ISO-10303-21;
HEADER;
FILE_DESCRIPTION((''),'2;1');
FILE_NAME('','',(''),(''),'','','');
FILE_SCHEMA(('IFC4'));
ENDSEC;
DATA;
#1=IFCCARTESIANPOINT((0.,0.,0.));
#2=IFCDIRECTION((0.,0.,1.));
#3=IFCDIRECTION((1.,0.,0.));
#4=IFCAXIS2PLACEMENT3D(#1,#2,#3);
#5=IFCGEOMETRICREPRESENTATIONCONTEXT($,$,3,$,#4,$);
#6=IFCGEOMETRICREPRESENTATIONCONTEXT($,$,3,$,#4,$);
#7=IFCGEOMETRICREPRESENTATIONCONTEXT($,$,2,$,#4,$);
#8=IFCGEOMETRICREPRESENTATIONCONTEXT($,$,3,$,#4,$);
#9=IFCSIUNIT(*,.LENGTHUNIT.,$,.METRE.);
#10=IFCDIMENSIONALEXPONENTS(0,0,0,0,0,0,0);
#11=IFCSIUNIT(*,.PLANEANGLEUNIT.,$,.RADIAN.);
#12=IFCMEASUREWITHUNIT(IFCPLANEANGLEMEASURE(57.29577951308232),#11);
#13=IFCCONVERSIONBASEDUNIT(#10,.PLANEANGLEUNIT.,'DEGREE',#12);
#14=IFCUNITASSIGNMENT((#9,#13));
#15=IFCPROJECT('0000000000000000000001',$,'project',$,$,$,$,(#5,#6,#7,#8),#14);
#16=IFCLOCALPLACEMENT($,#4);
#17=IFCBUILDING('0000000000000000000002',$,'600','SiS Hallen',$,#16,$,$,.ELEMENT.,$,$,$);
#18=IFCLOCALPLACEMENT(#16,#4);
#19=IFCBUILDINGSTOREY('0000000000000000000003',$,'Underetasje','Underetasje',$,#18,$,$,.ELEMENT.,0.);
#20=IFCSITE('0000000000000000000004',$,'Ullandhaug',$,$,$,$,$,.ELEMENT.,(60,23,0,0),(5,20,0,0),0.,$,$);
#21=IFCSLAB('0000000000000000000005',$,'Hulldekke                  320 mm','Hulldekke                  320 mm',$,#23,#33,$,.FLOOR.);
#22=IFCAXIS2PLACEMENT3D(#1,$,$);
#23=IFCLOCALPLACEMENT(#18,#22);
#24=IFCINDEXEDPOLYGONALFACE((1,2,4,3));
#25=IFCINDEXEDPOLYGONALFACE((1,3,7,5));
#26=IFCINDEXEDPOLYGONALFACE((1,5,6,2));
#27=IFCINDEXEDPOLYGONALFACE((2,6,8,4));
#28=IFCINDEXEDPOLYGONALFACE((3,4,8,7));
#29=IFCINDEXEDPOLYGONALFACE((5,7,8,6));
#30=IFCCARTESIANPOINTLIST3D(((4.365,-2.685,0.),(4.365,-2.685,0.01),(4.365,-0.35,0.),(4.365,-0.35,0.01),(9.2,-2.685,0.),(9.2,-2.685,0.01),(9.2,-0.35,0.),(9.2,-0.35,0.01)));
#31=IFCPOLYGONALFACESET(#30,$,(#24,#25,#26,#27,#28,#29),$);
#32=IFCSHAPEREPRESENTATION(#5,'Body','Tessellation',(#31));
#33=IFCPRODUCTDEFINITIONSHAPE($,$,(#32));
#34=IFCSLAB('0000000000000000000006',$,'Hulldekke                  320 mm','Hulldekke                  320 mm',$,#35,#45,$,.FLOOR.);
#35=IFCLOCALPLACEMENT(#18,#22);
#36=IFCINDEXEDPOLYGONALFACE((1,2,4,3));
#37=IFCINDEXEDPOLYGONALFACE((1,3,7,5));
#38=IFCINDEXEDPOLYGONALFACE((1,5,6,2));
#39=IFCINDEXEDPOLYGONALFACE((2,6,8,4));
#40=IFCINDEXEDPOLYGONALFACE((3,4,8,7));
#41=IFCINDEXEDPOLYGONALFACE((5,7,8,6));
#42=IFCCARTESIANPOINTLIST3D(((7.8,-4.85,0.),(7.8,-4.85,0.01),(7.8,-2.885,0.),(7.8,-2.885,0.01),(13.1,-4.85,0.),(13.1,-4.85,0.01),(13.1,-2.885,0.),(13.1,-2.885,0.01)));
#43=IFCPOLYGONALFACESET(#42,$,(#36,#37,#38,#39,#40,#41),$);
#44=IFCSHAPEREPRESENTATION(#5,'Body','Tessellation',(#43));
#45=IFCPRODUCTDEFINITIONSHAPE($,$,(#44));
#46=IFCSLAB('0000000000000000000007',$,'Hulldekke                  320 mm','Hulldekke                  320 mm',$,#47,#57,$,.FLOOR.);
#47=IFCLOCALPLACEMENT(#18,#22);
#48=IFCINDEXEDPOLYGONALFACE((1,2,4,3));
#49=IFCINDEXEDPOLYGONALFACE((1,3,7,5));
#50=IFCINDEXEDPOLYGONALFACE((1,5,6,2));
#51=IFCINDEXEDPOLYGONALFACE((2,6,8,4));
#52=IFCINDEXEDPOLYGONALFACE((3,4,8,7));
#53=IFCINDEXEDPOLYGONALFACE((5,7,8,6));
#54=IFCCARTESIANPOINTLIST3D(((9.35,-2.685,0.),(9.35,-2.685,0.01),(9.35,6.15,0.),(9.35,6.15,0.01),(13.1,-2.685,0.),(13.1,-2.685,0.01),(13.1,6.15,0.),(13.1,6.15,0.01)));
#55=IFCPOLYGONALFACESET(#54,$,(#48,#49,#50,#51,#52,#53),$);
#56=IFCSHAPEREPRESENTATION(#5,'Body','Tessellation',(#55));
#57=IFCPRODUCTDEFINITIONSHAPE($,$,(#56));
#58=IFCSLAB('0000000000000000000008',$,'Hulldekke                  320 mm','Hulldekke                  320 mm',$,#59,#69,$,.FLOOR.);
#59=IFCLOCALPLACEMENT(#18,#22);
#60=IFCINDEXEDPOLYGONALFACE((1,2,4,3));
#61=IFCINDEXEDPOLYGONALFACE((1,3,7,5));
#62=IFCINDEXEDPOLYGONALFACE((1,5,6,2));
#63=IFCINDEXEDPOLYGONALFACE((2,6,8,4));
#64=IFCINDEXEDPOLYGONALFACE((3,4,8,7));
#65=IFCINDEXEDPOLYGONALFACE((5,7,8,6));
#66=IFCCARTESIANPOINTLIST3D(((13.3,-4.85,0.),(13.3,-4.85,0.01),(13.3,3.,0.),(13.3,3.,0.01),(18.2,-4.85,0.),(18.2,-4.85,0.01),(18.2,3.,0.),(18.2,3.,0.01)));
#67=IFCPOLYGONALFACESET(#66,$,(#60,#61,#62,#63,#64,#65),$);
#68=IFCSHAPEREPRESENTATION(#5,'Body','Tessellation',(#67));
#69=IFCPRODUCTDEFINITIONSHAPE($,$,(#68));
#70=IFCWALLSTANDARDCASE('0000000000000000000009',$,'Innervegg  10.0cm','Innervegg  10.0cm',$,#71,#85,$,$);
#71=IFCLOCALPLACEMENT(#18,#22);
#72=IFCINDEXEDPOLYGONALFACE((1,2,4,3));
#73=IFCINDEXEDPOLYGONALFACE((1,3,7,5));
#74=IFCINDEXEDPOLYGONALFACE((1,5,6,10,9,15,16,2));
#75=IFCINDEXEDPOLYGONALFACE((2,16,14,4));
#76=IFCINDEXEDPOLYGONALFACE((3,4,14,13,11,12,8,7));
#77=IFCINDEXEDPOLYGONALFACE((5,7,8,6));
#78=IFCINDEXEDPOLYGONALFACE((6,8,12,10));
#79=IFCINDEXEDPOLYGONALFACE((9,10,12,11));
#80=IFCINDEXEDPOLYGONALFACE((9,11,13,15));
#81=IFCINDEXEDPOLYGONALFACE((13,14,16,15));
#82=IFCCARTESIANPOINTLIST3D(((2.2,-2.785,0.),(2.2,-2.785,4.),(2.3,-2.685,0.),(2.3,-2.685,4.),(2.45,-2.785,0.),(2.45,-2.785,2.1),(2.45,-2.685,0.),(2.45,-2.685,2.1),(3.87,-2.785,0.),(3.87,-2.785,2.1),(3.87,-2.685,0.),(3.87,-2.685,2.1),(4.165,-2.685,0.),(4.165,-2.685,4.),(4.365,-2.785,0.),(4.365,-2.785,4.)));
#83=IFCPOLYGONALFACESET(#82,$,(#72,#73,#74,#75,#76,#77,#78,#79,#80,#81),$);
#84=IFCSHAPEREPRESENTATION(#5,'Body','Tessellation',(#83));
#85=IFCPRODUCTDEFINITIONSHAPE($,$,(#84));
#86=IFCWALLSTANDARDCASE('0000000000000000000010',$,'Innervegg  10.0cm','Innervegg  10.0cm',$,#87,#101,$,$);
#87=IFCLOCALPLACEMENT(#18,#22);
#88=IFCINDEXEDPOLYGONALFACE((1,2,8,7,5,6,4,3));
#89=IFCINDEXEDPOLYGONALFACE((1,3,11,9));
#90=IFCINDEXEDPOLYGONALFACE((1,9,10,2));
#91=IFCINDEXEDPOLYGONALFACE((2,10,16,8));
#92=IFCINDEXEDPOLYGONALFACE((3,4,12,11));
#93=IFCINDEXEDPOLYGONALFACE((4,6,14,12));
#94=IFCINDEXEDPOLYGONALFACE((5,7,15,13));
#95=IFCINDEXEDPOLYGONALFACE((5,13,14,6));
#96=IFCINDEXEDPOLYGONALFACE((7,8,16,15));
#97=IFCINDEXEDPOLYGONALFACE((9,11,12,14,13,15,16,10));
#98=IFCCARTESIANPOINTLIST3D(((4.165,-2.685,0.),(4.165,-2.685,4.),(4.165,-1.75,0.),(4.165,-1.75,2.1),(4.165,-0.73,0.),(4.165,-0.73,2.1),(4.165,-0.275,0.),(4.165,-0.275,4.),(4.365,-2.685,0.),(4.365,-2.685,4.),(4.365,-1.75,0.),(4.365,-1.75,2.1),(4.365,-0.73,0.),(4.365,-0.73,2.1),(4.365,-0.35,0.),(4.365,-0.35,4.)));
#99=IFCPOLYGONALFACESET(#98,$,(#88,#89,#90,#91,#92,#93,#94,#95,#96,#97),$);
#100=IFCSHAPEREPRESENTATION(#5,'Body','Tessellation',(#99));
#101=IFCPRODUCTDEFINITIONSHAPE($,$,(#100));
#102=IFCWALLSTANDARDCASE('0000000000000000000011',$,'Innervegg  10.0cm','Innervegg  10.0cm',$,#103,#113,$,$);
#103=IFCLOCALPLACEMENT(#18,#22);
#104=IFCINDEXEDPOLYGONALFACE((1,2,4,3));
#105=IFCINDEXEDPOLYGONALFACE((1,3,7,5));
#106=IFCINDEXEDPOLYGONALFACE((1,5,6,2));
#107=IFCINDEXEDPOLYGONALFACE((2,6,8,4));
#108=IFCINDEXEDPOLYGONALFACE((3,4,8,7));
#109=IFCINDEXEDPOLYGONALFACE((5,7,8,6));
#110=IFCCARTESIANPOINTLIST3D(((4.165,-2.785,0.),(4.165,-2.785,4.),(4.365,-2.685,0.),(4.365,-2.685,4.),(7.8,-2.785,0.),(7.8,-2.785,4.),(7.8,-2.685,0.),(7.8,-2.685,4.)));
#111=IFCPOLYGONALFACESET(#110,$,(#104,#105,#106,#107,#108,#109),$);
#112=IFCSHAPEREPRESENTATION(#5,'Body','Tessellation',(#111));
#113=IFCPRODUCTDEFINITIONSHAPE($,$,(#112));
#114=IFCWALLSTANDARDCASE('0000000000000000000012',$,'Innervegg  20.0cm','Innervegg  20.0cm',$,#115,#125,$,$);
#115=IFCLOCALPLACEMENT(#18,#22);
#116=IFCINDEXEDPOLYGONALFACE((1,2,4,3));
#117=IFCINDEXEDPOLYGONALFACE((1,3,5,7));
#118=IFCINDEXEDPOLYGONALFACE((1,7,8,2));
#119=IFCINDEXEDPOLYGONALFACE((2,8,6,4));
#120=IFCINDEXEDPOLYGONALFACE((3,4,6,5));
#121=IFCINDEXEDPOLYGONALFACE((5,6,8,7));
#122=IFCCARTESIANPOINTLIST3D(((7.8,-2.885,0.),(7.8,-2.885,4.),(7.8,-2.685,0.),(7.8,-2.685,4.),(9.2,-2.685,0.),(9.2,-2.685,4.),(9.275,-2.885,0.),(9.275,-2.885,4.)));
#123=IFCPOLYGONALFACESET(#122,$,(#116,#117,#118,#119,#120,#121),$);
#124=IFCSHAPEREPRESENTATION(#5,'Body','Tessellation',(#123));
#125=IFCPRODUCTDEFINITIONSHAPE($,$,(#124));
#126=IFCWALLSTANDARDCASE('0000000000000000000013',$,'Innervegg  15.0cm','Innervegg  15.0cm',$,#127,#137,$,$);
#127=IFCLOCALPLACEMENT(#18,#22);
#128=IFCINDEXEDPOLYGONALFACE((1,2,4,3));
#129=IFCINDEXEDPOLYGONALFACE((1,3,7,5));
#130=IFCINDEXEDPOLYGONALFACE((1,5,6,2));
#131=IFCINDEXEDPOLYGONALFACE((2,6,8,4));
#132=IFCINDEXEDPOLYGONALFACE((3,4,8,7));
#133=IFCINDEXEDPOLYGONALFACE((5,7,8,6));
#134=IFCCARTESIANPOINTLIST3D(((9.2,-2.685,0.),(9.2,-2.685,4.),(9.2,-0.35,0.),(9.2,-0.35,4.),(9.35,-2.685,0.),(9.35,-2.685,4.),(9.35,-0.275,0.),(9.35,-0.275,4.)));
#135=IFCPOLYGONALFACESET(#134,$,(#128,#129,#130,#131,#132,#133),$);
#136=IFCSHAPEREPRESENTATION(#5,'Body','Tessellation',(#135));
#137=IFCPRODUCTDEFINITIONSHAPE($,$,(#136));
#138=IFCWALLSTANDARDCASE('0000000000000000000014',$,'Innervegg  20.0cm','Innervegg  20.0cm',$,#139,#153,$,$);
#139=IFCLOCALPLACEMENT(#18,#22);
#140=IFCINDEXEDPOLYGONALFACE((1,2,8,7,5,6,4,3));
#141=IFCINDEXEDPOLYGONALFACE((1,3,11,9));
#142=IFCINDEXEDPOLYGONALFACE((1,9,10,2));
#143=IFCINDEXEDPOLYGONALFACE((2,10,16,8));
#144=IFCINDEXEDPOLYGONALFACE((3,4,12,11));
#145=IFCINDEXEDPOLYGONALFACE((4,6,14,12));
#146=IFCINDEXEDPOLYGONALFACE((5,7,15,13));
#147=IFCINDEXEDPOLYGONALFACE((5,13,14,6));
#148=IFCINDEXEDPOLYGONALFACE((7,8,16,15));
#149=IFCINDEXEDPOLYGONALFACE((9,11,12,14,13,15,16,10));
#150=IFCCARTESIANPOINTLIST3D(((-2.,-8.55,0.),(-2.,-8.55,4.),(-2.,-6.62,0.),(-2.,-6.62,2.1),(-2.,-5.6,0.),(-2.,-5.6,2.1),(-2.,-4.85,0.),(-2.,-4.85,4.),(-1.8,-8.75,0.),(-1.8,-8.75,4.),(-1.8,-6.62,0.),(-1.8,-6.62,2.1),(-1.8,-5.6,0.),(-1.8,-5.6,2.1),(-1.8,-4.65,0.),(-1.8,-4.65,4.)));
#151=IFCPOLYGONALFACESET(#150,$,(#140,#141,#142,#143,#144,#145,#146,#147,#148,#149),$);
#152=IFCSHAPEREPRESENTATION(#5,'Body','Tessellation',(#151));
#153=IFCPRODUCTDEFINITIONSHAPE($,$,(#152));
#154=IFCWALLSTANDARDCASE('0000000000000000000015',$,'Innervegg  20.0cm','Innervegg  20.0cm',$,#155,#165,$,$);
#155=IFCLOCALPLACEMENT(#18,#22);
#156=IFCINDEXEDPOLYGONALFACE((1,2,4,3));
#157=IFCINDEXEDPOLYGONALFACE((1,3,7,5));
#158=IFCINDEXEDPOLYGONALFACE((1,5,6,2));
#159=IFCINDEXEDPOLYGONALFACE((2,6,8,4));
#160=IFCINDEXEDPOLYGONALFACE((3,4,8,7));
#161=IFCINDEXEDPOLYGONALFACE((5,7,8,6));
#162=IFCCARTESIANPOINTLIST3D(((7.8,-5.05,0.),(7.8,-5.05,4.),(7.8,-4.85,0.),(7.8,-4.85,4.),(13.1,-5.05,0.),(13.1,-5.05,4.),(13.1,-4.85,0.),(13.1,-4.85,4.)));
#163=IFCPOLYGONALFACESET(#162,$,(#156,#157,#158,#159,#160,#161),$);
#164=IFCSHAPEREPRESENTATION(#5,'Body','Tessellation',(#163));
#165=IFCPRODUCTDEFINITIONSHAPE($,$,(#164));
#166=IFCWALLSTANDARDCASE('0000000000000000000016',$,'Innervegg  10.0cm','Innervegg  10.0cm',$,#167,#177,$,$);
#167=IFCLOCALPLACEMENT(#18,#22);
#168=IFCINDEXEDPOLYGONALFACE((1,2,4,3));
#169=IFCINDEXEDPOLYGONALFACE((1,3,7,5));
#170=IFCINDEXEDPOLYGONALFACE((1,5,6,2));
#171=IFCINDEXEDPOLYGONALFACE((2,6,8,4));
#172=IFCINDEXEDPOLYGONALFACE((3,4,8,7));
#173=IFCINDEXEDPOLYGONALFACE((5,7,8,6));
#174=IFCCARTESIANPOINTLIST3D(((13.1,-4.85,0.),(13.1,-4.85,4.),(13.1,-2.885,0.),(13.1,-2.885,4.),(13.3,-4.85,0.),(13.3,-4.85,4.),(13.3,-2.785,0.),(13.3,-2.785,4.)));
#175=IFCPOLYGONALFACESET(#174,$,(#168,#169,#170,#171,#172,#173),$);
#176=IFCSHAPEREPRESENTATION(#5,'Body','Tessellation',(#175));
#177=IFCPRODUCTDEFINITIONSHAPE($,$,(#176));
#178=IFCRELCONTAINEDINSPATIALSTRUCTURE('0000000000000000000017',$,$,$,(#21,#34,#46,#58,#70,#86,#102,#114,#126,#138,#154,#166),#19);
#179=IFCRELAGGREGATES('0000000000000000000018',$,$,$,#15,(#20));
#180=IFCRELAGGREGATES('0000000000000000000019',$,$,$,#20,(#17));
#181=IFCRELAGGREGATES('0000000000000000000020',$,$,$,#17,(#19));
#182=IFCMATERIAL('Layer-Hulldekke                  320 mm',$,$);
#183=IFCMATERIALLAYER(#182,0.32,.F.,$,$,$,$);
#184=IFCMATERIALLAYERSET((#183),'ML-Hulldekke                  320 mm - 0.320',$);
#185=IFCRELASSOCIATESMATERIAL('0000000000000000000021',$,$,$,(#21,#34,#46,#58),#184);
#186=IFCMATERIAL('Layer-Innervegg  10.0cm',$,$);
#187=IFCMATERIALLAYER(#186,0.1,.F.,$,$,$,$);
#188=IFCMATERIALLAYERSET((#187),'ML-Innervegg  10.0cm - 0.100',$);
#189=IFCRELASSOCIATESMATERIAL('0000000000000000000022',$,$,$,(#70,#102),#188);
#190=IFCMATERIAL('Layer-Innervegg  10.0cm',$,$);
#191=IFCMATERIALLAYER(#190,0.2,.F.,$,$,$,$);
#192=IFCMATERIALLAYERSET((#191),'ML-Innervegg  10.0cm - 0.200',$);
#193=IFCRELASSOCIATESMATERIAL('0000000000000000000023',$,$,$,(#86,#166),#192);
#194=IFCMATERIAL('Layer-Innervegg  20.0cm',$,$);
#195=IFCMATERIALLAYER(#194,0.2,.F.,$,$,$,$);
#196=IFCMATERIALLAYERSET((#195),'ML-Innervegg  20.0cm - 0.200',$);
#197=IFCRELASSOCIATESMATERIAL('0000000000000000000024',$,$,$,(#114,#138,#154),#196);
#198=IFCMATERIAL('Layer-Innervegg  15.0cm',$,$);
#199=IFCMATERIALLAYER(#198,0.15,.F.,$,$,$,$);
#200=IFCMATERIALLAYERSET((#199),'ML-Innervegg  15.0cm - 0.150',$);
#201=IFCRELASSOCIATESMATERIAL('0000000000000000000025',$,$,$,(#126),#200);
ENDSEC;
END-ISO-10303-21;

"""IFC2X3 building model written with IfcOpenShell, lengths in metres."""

from ifc_helpers import new_model, entity, si_unit, converted_unit, frame, origin_with_axes, place, context, project, spatial, polyline, outline, extrude, material, layer, layer_set, layer_usage, element, save


model = new_model("IFC2X3")

# Units and contexts
context_of_model_1 = context(None, 3, world=origin_with_axes())
context_of_model_2 = context(None, 3, world=origin_with_axes())
context_of_model_3 = context(None, 2, world=origin_with_axes())
context_of_model_4 = context(None, 3, world=origin_with_axes())
ifc_project = project(units=[si_unit("LENGTHUNIT", "METRE"), converted_unit("PLANEANGLEUNIT", "DEGREE", entity("IfcPlaneAngleMeasure", 57.29577951308232), si_unit("PLANEANGLEUNIT", "RADIAN"), dimensions=[0, 0, 0, 0, 0, 0, 0])], contexts=[context_of_model_1, context_of_model_2, context_of_model_3, context_of_model_4])

# Site, building, storey
site = spatial("IfcSite", under=ifc_project, Name="Ullandhaug", CompositionType="ELEMENT", RefLatitude=(60, 23, 0, 0), RefLongitude=(5, 20, 0, 0), RefElevation=0.0)
building_placement = place(None, origin_with_axes())
building = spatial("IfcBuilding", under=site, at=building_placement, Name="600", Description="SiS Hallen", CompositionType="ELEMENT")
storey_placement = place(building_placement, origin_with_axes())
storey = spatial("IfcBuildingStorey", under=building, at=storey_placement, Name="Underetasje", Description="Underetasje", CompositionType="ELEMENT", Elevation=0.0)

# Slabs
ifc_material_1 = material(Name="Layer-Hulldekke                  320 mm")
ifc_layer_1 = layer(ifc_material_1, 0.32, ventilated=False)
ifc_layer_set_1 = layer_set([ifc_layer_1], Name="ML-Hulldekke                  320 mm - 0.320")
ifc_layer_usage_1 = layer_usage(ifc_layer_set_1, "AXIS2", "POSITIVE", 0.0)
slab_1_placement = place(storey_placement, frame((4.365, -2.685, 0.0), z_axis=(0.0, 0.0, 1.0), x_axis=(1.0, 0.0, 0.0)))
element("IfcSlab", 1, at=slab_1_placement, inside=storey, material=ifc_layer_usage_1, Name="Hulldekke                  320 mm", Description="Hulldekke                  320 mm", PredefinedType="FLOOR", context=context_of_model_1, shape_type="SweptSolid", body=[
    extrude(outline(polyline([(0.0, 0.0), (4.835, 0.0), (4.835, 2.335), (0.0, 2.335), (0.0, 0.0)])), origin_with_axes(), (0.0, 0.0, 1.0), 0.01),
])
slab_2_placement = place(storey_placement, frame((7.8, -4.85, 0.0), z_axis=(0.0, 0.0, 1.0), x_axis=(1.0, 0.0, 0.0)))
element("IfcSlab", 2, at=slab_2_placement, inside=storey, material=ifc_layer_usage_1, Name="Hulldekke                  320 mm", Description="Hulldekke                  320 mm", PredefinedType="FLOOR", context=context_of_model_1, shape_type="SweptSolid", body=[
    extrude(outline(polyline([(0.0, 0.0), (5.3, 0.0), (5.3, 1.965), (0.0, 1.965), (0.0, 0.0)])), origin_with_axes(), (0.0, 0.0, 1.0), 0.01),
])
slab_3_placement = place(storey_placement, frame((9.35, -2.685, 0.0), z_axis=(0.0, 0.0, 1.0), x_axis=(1.0, 0.0, 0.0)))
element("IfcSlab", 3, at=slab_3_placement, inside=storey, material=ifc_layer_usage_1, Name="Hulldekke                  320 mm", Description="Hulldekke                  320 mm", PredefinedType="FLOOR", context=context_of_model_1, shape_type="SweptSolid", body=[
    extrude(outline(polyline([(0.0, 0.0), (3.75, 0.0), (3.75, 8.835), (0.0, 8.835), (0.0, 0.0)])), origin_with_axes(), (0.0, 0.0, 1.0), 0.01),
])
slab_4_placement = place(storey_placement, frame((13.3, -4.85, 0.0), z_axis=(0.0, 0.0, 1.0), x_axis=(1.0, 0.0, 0.0)))
element("IfcSlab", 4, at=slab_4_placement, inside=storey, material=ifc_layer_usage_1, Name="Hulldekke                  320 mm", Description="Hulldekke                  320 mm", PredefinedType="FLOOR", context=context_of_model_1, shape_type="SweptSolid", body=[
    extrude(outline(polyline([(0.0, 0.0), (4.9, 0.0), (4.9, 7.85), (0.0, 7.85), (0.0, 0.0)])), origin_with_axes(), (0.0, 0.0, 1.0), 0.01),
])

# Walls, openings
ifc_material_2 = material(Name="Layer-Innervegg  10.0cm")
ifc_layer_2 = layer(ifc_material_2, 0.1, ventilated=False)
ifc_layer_set_2 = layer_set([ifc_layer_2], Name="ML-Innervegg  10.0cm - 0.100")
ifc_layer_usage_2 = layer_usage(ifc_layer_set_2, "AXIS2", "POSITIVE", 0.0)
wall_1_placement = place(storey_placement, frame((2.2, -2.785, 0.0), z_axis=(0.0, 0.0, 1.0), x_axis=(1.0, 0.0, 0.0)))
wall_1 = element("IfcWallStandardCase", 5, at=wall_1_placement, inside=storey, material=ifc_layer_usage_2, Name="Innervegg  10.0cm", Description="Innervegg  10.0cm", context=context_of_model_1, shape_type="SweptSolid", body=[
    extrude(outline(polyline([(0.0, 0.0), (2.165, 0.0), (1.965, 0.1), (0.1, 0.1), (0.0, 0.0)])), origin_with_axes(), (0.0, 0.0, 1.0), 4.0),
])
opening_1_placement = place(wall_1_placement, frame((0.25, 0.1, 0.0), z_axis=(0.0, 0.0, 1.0), x_axis=(1.0, 0.0, 0.0)))
element("IfcOpeningElement", 6, at=opening_1_placement, cuts=wall_1, context=context_of_model_1, shape_type="SweptSolid", body=[
    extrude(outline(polyline([(0.0, 0.0), (2.1, 0.0), (2.1, 1.42), (0.0, 1.42), (0.0, 0.0)])), frame((0.0, 0.0, 0.0), z_axis=(0.0, 1.0, 0.0), x_axis=(0.0, 0.0, 1.0)), (0.0, 0.0, -1.0), 0.1),
])
ifc_material_3 = material(Name="Layer-Innervegg  10.0cm")
ifc_layer_3 = layer(ifc_material_3, 0.2, ventilated=False)
ifc_layer_set_3 = layer_set([ifc_layer_3], Name="ML-Innervegg  10.0cm - 0.200")
ifc_layer_usage_3 = layer_usage(ifc_layer_set_3, "AXIS2", "POSITIVE", 0.0)
wall_2_placement = place(storey_placement, frame((4.365, -2.685, 0.0), z_axis=(0.0, 0.0, 1.0), x_axis=(0.0, 1.0, 0.0)))
wall_2 = element("IfcWallStandardCase", 7, at=wall_2_placement, inside=storey, material=ifc_layer_usage_3, Name="Innervegg  10.0cm", Description="Innervegg  10.0cm", context=context_of_model_1, shape_type="SweptSolid", body=[
    extrude(outline(polyline([(0.0, 0.0), (2.335, 0.0), (2.41, 0.2), (0.0, 0.2), (0.0, 0.0)])), frame((0.0, 0.0, 0.0), z_axis=(0.0, 0.0, 1.0), x_axis=(1.0, 0.0, 0.0)), (0.0, 0.0, 1.0), 4.0),
])
opening_2_placement = place(wall_2_placement, frame((0.935, 0.2, 0.0), z_axis=(0.0, 0.0, 1.0), x_axis=(1.0, 0.0, 0.0)))
element("IfcOpeningElement", 8, at=opening_2_placement, cuts=wall_2, context=context_of_model_1, shape_type="SweptSolid", body=[
    extrude(outline(polyline([(0.0, 0.0), (2.1, 0.0), (2.1, 1.02), (0.0, 1.02), (0.0, 0.0)])), frame((0.0, 0.0, 0.0), z_axis=(0.0, 1.0, 0.0), x_axis=(0.0, 0.0, 1.0)), (0.0, 0.0, -1.0), 0.2),
])

# Walls
wall_3_placement = place(storey_placement, frame((4.165, -2.785, 0.0), z_axis=(0.0, 0.0, 1.0), x_axis=(1.0, 0.0, 0.0)))
element("IfcWallStandardCase", 9, at=wall_3_placement, inside=storey, material=ifc_layer_usage_2, Name="Innervegg  10.0cm", Description="Innervegg  10.0cm", context=context_of_model_1, shape_type="SweptSolid", body=[
    extrude(outline(polyline([(0.0, 0.0), (3.635, 0.0), (3.635, 0.1), (0.2, 0.1), (0.0, 0.0)])), origin_with_axes(), (0.0, 0.0, 1.0), 4.0),
])
ifc_material_4 = material(Name="Layer-Innervegg  20.0cm")
ifc_layer_4 = layer(ifc_material_4, 0.2, ventilated=False)
ifc_layer_set_4 = layer_set([ifc_layer_4], Name="ML-Innervegg  20.0cm - 0.200")
ifc_layer_usage_4 = layer_usage(ifc_layer_set_4, "AXIS2", "POSITIVE", 0.0)
wall_4_placement = place(storey_placement, frame((7.8, -2.885, 0.0), z_axis=(0.0, 0.0, 1.0), x_axis=(1.0, 0.0, 0.0)))
element("IfcWallStandardCase", 10, at=wall_4_placement, inside=storey, material=ifc_layer_usage_4, Name="Innervegg  20.0cm", Description="Innervegg  20.0cm", context=context_of_model_1, shape_type="SweptSolid", body=[
    extrude(outline(polyline([(0.0, 0.0), (1.475, 0.0), (1.4, 0.2), (0.0, 0.2), (0.0, 0.0)])), origin_with_axes(), (0.0, 0.0, 1.0), 4.0),
])
ifc_material_5 = material(Name="Layer-Innervegg  15.0cm")
ifc_layer_5 = layer(ifc_material_5, 0.15, ventilated=False)
ifc_layer_set_5 = layer_set([ifc_layer_5], Name="ML-Innervegg  15.0cm - 0.150")
ifc_layer_usage_5 = layer_usage(ifc_layer_set_5, "AXIS2", "POSITIVE", 0.0)
wall_5_placement = place(storey_placement, frame((9.35, -2.685, 0.0), z_axis=(0.0, 0.0, 1.0), x_axis=(0.0, 1.0, 0.0)))
element("IfcWallStandardCase", 11, at=wall_5_placement, inside=storey, material=ifc_layer_usage_5, Name="Innervegg  15.0cm", Description="Innervegg  15.0cm", context=context_of_model_1, shape_type="SweptSolid", body=[
    extrude(outline(polyline([(0.0, 0.0), (2.41, 0.0), (2.335, 0.15), (0.0, 0.15), (0.0, 0.0)])), frame((0.0, 0.0, 0.0), z_axis=(0.0, 0.0, 1.0), x_axis=(1.0, 0.0, 0.0)), (0.0, 0.0, 1.0), 4.0),
])

# Wall, opening
wall_6_placement = place(storey_placement, frame((-1.8, -8.75, 0.0), z_axis=(0.0, 0.0, 1.0), x_axis=(0.0, 1.0, 0.0)))
wall_6 = element("IfcWallStandardCase", 12, at=wall_6_placement, inside=storey, material=ifc_layer_usage_4, Name="Innervegg  20.0cm", Description="Innervegg  20.0cm", context=context_of_model_1, shape_type="SweptSolid", body=[
    extrude(outline(polyline([(0.0, 0.0), (4.1, 0.0), (3.9, 0.2), (0.2, 0.2), (0.0, 0.0)])), frame((0.0, 0.0, 0.0), z_axis=(0.0, 0.0, 1.0), x_axis=(1.0, 0.0, 0.0)), (0.0, 0.0, 1.0), 4.0),
])
opening_3_placement = place(wall_6_placement, frame((2.13, 0.2, 0.0), z_axis=(0.0, 0.0, 1.0), x_axis=(1.0, 0.0, 0.0)))
element("IfcOpeningElement", 13, at=opening_3_placement, cuts=wall_6, context=context_of_model_1, shape_type="SweptSolid", body=[
    extrude(outline(polyline([(0.0, 0.0), (2.1, 0.0), (2.1, 1.02), (0.0, 1.02), (0.0, 0.0)])), frame((0.0, 0.0, 0.0), z_axis=(0.0, 1.0, 0.0), x_axis=(0.0, 0.0, 1.0)), (0.0, 0.0, -1.0), 0.2),
])

# Walls
wall_7_placement = place(storey_placement, frame((7.8, -5.05, 0.0), z_axis=(0.0, 0.0, 1.0), x_axis=(1.0, 0.0, 0.0)))
element("IfcWallStandardCase", 14, at=wall_7_placement, inside=storey, material=ifc_layer_usage_4, Name="Innervegg  20.0cm", Description="Innervegg  20.0cm", context=context_of_model_1, shape_type="SweptSolid", body=[
    extrude(outline(polyline([(0.0, 0.0), (5.3, 0.0), (5.3, 0.2), (0.0, 0.2), (0.0, 0.0)])), origin_with_axes(), (0.0, 0.0, 1.0), 4.0),
])
wall_8_placement = place(storey_placement, frame((13.3, -4.85, 0.0), z_axis=(0.0, 0.0, 1.0), x_axis=(0.0, 1.0, 0.0)))
element("IfcWallStandardCase", 15, at=wall_8_placement, inside=storey, material=ifc_layer_usage_3, Name="Innervegg  10.0cm", Description="Innervegg  10.0cm", context=context_of_model_1, shape_type="SweptSolid", body=[
    extrude(outline(polyline([(0.0, 0.0), (2.065, 0.0), (1.965, 0.2), (0.0, 0.2), (0.0, 0.0)])), frame((0.0, 0.0, 0.0), z_axis=(0.0, 0.0, 1.0), x_axis=(1.0, 0.0, 0.0)), (0.0, 0.0, 1.0), 4.0),
])

save(model, "model.ifc")
